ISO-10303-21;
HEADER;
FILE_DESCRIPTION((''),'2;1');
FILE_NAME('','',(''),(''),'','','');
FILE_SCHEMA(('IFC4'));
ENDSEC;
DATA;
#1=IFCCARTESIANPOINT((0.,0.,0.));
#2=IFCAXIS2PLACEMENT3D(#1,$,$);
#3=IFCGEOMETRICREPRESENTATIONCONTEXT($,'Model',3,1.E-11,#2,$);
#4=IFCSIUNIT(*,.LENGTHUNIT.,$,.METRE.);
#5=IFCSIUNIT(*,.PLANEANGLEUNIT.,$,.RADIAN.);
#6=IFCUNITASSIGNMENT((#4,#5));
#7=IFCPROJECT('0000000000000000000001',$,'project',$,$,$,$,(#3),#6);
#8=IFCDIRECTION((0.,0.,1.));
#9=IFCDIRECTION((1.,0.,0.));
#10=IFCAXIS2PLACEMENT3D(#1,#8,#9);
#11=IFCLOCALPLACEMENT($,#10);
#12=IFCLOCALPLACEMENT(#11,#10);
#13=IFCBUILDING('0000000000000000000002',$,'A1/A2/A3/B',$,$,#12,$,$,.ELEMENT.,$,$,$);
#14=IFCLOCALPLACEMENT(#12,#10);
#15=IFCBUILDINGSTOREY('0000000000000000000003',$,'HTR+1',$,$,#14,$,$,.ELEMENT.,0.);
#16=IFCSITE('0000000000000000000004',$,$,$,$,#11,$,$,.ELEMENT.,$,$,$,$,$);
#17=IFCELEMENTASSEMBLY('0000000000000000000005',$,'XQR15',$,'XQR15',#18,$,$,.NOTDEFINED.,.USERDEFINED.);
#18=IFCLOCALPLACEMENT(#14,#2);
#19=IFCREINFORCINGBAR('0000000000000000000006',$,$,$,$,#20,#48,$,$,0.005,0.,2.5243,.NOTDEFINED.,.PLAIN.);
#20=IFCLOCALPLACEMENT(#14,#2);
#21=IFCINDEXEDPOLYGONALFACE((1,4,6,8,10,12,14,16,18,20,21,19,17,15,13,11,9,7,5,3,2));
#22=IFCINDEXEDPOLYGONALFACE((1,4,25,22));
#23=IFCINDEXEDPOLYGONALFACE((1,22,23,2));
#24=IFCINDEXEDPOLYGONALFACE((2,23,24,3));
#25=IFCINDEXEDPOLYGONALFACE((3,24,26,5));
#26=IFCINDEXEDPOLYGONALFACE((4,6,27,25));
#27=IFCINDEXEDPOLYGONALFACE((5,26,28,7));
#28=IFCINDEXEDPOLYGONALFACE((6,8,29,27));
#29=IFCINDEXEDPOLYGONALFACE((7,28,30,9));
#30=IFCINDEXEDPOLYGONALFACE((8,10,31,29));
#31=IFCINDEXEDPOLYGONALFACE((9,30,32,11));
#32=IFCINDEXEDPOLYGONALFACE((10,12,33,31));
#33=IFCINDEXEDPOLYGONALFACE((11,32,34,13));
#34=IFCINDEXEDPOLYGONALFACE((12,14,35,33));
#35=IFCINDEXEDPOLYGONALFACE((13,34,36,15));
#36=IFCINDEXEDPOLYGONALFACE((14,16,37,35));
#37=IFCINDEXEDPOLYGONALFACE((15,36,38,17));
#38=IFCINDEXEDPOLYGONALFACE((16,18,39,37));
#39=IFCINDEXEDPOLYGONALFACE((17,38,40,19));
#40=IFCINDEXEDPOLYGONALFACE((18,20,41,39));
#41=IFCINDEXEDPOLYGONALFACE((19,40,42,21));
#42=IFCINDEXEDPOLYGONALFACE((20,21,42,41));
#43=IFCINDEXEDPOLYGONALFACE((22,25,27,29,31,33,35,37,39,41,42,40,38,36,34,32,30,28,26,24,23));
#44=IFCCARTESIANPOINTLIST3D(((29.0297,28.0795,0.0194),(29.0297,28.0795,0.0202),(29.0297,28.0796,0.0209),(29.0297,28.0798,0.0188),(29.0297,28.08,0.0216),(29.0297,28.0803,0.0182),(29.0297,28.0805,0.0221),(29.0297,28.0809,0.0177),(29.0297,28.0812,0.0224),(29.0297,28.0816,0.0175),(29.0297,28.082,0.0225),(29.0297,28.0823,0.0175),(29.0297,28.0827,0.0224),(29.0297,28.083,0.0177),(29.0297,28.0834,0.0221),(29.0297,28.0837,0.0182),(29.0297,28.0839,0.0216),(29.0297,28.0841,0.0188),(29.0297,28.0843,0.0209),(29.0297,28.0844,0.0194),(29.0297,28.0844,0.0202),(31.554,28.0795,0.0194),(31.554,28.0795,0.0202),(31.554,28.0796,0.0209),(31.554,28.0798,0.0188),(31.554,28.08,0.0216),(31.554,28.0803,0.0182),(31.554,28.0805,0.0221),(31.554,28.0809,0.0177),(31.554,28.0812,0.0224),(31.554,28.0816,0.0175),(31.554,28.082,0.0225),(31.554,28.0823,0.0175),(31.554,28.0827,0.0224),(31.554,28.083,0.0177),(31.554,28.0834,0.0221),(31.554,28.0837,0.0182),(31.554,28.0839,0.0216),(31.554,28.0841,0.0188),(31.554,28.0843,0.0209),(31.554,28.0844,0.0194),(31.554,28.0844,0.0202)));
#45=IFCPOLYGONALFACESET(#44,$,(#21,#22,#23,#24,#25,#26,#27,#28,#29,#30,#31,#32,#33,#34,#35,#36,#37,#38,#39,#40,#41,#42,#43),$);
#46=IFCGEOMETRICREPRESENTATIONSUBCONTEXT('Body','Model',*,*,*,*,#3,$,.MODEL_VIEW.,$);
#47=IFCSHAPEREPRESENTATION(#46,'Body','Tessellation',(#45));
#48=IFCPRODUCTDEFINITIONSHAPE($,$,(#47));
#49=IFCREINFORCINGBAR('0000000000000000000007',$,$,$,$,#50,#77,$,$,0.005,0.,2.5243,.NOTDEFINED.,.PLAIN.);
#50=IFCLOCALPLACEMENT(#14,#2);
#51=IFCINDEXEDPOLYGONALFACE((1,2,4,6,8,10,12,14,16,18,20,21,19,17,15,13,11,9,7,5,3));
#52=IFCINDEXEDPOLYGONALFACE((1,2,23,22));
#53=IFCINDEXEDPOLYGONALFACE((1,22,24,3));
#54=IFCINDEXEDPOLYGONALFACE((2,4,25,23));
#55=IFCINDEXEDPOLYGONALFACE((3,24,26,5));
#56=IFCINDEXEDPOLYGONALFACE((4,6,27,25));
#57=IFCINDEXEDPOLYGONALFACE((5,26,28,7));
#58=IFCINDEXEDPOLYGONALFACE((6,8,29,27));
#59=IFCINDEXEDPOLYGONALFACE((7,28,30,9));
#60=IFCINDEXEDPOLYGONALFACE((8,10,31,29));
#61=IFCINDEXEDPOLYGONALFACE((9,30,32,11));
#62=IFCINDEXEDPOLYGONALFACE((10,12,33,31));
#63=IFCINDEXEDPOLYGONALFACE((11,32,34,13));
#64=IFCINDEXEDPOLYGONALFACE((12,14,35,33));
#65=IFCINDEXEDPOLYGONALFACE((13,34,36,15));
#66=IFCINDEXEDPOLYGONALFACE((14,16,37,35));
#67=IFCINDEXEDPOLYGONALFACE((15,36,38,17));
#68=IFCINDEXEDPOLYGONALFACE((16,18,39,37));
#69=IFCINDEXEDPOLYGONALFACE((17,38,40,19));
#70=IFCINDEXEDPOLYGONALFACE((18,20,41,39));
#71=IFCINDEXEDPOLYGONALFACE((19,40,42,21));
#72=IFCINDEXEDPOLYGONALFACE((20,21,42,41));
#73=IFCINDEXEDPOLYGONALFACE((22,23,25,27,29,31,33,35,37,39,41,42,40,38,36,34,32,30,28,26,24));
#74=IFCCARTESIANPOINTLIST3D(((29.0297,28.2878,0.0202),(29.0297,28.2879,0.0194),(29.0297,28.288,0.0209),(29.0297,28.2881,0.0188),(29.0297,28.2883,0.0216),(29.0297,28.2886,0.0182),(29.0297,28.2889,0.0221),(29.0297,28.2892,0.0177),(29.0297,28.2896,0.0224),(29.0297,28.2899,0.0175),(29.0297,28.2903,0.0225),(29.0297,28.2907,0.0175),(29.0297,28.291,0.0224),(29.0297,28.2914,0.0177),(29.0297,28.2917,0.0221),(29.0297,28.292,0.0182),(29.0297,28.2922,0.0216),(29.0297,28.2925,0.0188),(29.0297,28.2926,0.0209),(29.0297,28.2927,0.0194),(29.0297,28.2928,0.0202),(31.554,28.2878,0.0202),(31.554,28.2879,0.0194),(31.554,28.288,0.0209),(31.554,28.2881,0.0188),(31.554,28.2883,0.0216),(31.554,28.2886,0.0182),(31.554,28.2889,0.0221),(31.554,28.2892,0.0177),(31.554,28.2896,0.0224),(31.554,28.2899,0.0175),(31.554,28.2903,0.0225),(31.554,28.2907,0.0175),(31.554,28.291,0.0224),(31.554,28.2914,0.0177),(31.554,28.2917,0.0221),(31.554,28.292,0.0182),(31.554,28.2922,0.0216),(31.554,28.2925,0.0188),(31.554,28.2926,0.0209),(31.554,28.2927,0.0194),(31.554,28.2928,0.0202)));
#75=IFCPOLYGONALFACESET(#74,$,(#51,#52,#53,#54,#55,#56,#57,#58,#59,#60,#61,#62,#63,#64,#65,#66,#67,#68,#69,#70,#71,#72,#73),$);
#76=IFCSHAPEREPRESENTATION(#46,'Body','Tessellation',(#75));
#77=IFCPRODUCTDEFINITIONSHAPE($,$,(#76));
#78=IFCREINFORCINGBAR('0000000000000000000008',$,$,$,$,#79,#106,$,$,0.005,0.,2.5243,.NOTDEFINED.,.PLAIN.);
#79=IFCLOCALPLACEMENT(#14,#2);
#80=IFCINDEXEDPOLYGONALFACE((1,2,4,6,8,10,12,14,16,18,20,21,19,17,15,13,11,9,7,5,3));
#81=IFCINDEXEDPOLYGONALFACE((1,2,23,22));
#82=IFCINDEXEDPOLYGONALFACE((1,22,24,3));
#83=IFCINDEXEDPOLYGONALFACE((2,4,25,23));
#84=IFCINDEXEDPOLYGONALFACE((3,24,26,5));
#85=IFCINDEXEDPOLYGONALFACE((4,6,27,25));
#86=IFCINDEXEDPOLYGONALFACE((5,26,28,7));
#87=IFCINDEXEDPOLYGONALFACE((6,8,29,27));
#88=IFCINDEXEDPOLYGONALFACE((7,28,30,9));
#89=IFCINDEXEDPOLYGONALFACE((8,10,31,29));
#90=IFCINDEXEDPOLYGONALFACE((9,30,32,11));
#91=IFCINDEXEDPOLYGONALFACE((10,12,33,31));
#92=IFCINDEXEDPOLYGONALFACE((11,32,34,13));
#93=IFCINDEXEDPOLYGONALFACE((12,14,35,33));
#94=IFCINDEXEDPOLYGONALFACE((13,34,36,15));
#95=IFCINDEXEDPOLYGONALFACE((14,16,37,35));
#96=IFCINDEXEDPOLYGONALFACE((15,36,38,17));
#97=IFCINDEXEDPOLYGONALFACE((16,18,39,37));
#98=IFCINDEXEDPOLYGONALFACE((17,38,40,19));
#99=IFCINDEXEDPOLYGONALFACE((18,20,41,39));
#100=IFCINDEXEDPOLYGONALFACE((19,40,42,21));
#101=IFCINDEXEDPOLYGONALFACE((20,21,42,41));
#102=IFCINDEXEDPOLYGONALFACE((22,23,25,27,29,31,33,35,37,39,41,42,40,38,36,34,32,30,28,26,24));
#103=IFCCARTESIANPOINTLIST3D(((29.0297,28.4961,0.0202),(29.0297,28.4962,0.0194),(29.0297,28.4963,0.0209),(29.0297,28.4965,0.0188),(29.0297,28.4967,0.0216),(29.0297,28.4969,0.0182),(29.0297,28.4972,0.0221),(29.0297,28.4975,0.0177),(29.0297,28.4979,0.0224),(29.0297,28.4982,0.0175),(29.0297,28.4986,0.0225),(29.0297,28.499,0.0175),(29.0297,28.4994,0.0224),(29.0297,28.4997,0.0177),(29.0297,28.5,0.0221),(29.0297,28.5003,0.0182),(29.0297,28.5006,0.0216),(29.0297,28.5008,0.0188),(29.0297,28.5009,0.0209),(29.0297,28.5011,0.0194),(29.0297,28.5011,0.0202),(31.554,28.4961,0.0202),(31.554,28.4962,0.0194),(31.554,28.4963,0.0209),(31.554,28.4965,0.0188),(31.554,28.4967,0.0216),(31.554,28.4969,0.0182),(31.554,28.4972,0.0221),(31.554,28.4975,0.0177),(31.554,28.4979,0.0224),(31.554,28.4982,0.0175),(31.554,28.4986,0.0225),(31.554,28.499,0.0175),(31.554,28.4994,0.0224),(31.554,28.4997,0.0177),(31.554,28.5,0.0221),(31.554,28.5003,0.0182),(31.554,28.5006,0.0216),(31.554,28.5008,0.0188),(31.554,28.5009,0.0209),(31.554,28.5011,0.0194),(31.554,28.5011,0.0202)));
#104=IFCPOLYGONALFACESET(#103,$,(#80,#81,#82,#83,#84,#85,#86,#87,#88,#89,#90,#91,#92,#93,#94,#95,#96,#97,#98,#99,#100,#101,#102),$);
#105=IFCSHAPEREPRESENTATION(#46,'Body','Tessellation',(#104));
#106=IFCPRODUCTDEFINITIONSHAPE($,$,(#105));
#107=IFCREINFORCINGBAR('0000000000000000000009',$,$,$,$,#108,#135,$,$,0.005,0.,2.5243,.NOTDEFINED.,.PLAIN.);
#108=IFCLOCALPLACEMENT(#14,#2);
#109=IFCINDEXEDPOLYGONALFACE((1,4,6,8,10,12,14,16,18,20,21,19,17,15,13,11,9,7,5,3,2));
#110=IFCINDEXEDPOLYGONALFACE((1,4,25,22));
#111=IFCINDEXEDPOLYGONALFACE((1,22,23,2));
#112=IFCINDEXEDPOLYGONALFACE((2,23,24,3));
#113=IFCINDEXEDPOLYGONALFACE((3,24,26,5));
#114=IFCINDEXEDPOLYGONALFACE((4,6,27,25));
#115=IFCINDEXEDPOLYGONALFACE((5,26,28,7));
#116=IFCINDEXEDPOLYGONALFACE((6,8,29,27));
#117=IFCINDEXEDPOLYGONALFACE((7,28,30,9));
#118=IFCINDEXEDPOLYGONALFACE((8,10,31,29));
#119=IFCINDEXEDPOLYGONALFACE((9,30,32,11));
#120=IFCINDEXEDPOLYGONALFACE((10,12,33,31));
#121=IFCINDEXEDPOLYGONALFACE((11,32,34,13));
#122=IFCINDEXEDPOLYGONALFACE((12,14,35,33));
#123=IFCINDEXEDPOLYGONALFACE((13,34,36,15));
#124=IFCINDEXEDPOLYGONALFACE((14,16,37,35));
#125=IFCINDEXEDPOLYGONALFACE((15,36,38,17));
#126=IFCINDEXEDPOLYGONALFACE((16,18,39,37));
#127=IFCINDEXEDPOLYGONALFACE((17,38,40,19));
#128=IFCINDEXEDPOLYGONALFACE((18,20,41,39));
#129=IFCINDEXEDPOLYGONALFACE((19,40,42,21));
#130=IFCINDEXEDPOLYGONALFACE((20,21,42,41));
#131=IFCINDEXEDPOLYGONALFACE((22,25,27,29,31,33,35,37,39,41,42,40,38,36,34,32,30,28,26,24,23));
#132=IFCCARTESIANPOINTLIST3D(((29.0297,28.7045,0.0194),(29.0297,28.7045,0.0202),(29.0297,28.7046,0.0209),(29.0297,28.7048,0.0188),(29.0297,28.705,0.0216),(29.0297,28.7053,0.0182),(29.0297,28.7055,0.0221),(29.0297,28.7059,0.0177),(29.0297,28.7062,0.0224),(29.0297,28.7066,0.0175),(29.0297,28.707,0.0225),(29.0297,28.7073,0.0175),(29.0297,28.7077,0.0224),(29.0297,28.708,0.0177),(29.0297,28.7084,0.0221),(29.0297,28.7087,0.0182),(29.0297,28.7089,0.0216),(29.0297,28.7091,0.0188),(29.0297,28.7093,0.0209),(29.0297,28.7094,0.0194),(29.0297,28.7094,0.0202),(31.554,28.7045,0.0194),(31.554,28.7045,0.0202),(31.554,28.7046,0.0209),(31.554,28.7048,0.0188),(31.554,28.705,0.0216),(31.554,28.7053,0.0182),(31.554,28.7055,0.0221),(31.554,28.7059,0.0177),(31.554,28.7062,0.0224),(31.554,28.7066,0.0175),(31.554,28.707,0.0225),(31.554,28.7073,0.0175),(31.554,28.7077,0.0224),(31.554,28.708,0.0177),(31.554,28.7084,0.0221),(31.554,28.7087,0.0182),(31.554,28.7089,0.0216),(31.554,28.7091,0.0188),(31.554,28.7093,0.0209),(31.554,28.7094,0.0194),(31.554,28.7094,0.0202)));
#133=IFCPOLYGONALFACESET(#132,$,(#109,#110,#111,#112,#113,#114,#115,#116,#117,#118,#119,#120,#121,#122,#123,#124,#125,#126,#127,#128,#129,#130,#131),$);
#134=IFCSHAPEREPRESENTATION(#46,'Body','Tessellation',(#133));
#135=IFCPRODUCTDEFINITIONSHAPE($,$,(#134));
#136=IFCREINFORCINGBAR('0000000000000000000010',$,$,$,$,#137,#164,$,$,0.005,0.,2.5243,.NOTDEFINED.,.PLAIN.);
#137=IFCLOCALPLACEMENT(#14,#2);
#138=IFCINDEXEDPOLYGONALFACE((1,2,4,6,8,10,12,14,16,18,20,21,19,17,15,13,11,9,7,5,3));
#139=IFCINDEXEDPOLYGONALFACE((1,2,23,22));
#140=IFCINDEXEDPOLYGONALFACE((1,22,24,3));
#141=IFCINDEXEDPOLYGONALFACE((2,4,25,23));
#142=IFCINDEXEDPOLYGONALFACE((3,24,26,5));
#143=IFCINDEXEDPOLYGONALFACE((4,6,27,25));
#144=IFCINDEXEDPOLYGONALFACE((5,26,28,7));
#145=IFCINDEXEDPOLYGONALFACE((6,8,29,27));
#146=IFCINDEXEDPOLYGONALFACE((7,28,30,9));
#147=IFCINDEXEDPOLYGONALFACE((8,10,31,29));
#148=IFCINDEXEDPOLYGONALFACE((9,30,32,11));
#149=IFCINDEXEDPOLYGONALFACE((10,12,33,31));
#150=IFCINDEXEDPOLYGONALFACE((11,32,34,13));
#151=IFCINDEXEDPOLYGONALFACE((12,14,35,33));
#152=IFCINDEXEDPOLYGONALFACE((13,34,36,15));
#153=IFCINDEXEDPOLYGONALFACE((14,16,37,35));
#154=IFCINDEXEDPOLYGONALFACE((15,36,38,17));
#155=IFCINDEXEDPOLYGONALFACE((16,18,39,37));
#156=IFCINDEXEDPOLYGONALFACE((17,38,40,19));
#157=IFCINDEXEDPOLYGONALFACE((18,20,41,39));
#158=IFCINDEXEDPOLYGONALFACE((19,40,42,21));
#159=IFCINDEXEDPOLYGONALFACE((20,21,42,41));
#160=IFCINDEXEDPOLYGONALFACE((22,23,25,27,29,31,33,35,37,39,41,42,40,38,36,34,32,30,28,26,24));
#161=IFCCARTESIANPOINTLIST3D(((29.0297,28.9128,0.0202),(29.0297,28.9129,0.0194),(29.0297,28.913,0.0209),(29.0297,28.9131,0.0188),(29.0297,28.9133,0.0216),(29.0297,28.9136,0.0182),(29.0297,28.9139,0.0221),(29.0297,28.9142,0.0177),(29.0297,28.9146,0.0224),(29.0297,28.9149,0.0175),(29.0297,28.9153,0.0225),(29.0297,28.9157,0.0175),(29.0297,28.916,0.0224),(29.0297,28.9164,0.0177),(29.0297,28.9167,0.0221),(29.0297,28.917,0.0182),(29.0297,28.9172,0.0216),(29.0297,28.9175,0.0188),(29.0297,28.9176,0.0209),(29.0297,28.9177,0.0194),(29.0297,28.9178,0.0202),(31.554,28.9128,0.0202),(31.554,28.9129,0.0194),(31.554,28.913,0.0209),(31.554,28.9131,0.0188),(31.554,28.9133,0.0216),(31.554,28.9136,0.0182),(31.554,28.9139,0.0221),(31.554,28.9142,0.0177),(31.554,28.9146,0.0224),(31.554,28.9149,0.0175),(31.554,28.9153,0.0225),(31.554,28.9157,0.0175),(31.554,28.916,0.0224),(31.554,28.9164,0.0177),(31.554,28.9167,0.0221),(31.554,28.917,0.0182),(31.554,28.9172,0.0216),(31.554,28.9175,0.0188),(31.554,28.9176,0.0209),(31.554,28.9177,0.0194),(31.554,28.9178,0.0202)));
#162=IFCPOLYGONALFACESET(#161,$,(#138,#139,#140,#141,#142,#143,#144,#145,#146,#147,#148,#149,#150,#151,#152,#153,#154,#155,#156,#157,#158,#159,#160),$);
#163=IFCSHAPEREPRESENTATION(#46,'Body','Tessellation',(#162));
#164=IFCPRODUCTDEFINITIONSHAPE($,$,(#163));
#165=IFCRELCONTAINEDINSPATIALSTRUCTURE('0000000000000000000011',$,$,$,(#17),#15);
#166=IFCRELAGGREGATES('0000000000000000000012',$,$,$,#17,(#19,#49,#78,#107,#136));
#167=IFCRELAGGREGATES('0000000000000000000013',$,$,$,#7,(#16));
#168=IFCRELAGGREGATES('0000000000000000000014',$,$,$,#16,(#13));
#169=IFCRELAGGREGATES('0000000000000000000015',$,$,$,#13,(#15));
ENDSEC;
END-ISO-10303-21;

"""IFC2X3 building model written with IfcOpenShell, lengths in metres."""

from ifc_helpers import new_model, entity, si_unit, origin, origin_with_axes, place, context, subcontext, project, spatial, shape, element, aggregate, save


model = new_model("IFC2X3")

# Units and contexts
model_context = context("Model", 3, precision=1e-11, world=origin())
body_context = subcontext(model_context, "Body", "Model", "MODEL_VIEW")
ifc_project = project(units=[si_unit("LENGTHUNIT", "METRE"), si_unit("PLANEANGLEUNIT", "RADIAN")], contexts=[model_context])

# Site, building, storey
site_placement = place(None, origin_with_axes())
site = spatial("IfcSite", under=ifc_project, at=site_placement, CompositionType="ELEMENT")
building_placement = place(site_placement, origin_with_axes())
building = spatial("IfcBuilding", under=site, at=building_placement, Name="A1/A2/A3/B", CompositionType="ELEMENT")
storey_placement = place(building_placement, origin_with_axes())
storey = spatial("IfcBuildingStorey", under=building, at=storey_placement, Name="HTR+1", CompositionType="ELEMENT", Elevation=0.0)

# Element assembly, reinforcing bars
assembly_1_placement = place(storey_placement, origin_with_axes())
assembly_1 = element("IfcElementAssembly", 1, at=assembly_1_placement, inside=storey, Name="XQR15", ObjectType="XQR15", AssemblyPlace="NOTDEFINED", PredefinedType="USERDEFINED")
reinforcing_bar_1_placement = place(assembly_1_placement, origin_with_axes())
reinforcing_bar_1 = element("IfcReinforcingBar", 2, at=reinforcing_bar_1_placement, BarLength=2.5243, BarRole="NOTDEFINED", BarSurface="PLAIN", CrossSectionArea=0.0, NominalDiameter=0.005, shapes=[
    shape(body_context, "Body", "AdvancedSweptSolid", [entity("IfcSweptDiskSolid", entity("IfcPolyline", [entity("IfcCartesianPoint", [29.0297, 28.082, 0.02]), entity("IfcCartesianPoint", [31.554, 28.082, 0.02])]), 0.0025, None, 0.0, 2.5243)]),
    shape(body_context, "Body", "AdvancedSweptSolid", [entity("IfcSweptDiskSolid", entity("IfcPolyline", [entity("IfcCartesianPoint", [29.0297, 28.082, 0.02]), entity("IfcCartesianPoint", [31.554, 28.082, 0.02])]), 0.0025, None, 0.0, 2.5243)]),
])
reinforcing_bar_2_placement = place(assembly_1_placement, origin_with_axes())
reinforcing_bar_2 = element("IfcReinforcingBar", 3, at=reinforcing_bar_2_placement, BarLength=2.5243, BarRole="NOTDEFINED", BarSurface="PLAIN", CrossSectionArea=0.0, NominalDiameter=0.005, shapes=[
    shape(body_context, "Body", "AdvancedSweptSolid", [entity("IfcSweptDiskSolid", entity("IfcPolyline", [entity("IfcCartesianPoint", [29.0297, 28.2903, 0.02]), entity("IfcCartesianPoint", [31.554, 28.2903, 0.02])]), 0.0025, None, 0.0, 2.5243)]),
    shape(body_context, "Body", "AdvancedSweptSolid", [entity("IfcSweptDiskSolid", entity("IfcPolyline", [entity("IfcCartesianPoint", [29.0297, 28.2903, 0.02]), entity("IfcCartesianPoint", [31.554, 28.2903, 0.02])]), 0.0025, None, 0.0, 2.5243)]),
])
reinforcing_bar_3_placement = place(assembly_1_placement, origin_with_axes())
reinforcing_bar_3 = element("IfcReinforcingBar", 4, at=reinforcing_bar_3_placement, BarLength=2.5243, BarRole="NOTDEFINED", BarSurface="PLAIN", CrossSectionArea=0.0, NominalDiameter=0.005, shapes=[
    shape(body_context, "Body", "AdvancedSweptSolid", [entity("IfcSweptDiskSolid", entity("IfcPolyline", [entity("IfcCartesianPoint", [29.0297, 28.4986, 0.02]), entity("IfcCartesianPoint", [31.554, 28.4986, 0.02])]), 0.0025, None, 0.0, 2.5243)]),
    shape(body_context, "Body", "AdvancedSweptSolid", [entity("IfcSweptDiskSolid", entity("IfcPolyline", [entity("IfcCartesianPoint", [29.0297, 28.4986, 0.02]), entity("IfcCartesianPoint", [31.554, 28.4986, 0.02])]), 0.0025, None, 0.0, 2.5243)]),
])
reinforcing_bar_4_placement = place(assembly_1_placement, origin_with_axes())
reinforcing_bar_4 = element("IfcReinforcingBar", 5, at=reinforcing_bar_4_placement, BarLength=2.5243, BarRole="NOTDEFINED", BarSurface="PLAIN", CrossSectionArea=0.0, NominalDiameter=0.005, shapes=[
    shape(body_context, "Body", "AdvancedSweptSolid", [entity("IfcSweptDiskSolid", entity("IfcPolyline", [entity("IfcCartesianPoint", [29.0297, 28.707, 0.02]), entity("IfcCartesianPoint", [31.554, 28.707, 0.02])]), 0.0025, None, 0.0, 2.5243)]),
    shape(body_context, "Body", "AdvancedSweptSolid", [entity("IfcSweptDiskSolid", entity("IfcPolyline", [entity("IfcCartesianPoint", [29.0297, 28.707, 0.02]), entity("IfcCartesianPoint", [31.554, 28.707, 0.02])]), 0.0025, None, 0.0, 2.5243)]),
])
reinforcing_bar_5_placement = place(assembly_1_placement, origin_with_axes())
reinforcing_bar_5 = element("IfcReinforcingBar", 6, at=reinforcing_bar_5_placement, BarLength=2.5243, BarRole="NOTDEFINED", BarSurface="PLAIN", CrossSectionArea=0.0, NominalDiameter=0.005, shapes=[
    shape(body_context, "Body", "AdvancedSweptSolid", [entity("IfcSweptDiskSolid", entity("IfcPolyline", [entity("IfcCartesianPoint", [29.0297, 28.9153, 0.02]), entity("IfcCartesianPoint", [31.554, 28.9153, 0.02])]), 0.0025, None, 0.0, 2.5243)]),
    shape(body_context, "Body", "AdvancedSweptSolid", [entity("IfcSweptDiskSolid", entity("IfcPolyline", [entity("IfcCartesianPoint", [29.0297, 28.9153, 0.02]), entity("IfcCartesianPoint", [31.554, 28.9153, 0.02])]), 0.0025, None, 0.0, 2.5243)]),
])
aggregate(assembly_1, [reinforcing_bar_1, reinforcing_bar_2, reinforcing_bar_3, reinforcing_bar_4, reinforcing_bar_5])

save(model, "model.ifc")
